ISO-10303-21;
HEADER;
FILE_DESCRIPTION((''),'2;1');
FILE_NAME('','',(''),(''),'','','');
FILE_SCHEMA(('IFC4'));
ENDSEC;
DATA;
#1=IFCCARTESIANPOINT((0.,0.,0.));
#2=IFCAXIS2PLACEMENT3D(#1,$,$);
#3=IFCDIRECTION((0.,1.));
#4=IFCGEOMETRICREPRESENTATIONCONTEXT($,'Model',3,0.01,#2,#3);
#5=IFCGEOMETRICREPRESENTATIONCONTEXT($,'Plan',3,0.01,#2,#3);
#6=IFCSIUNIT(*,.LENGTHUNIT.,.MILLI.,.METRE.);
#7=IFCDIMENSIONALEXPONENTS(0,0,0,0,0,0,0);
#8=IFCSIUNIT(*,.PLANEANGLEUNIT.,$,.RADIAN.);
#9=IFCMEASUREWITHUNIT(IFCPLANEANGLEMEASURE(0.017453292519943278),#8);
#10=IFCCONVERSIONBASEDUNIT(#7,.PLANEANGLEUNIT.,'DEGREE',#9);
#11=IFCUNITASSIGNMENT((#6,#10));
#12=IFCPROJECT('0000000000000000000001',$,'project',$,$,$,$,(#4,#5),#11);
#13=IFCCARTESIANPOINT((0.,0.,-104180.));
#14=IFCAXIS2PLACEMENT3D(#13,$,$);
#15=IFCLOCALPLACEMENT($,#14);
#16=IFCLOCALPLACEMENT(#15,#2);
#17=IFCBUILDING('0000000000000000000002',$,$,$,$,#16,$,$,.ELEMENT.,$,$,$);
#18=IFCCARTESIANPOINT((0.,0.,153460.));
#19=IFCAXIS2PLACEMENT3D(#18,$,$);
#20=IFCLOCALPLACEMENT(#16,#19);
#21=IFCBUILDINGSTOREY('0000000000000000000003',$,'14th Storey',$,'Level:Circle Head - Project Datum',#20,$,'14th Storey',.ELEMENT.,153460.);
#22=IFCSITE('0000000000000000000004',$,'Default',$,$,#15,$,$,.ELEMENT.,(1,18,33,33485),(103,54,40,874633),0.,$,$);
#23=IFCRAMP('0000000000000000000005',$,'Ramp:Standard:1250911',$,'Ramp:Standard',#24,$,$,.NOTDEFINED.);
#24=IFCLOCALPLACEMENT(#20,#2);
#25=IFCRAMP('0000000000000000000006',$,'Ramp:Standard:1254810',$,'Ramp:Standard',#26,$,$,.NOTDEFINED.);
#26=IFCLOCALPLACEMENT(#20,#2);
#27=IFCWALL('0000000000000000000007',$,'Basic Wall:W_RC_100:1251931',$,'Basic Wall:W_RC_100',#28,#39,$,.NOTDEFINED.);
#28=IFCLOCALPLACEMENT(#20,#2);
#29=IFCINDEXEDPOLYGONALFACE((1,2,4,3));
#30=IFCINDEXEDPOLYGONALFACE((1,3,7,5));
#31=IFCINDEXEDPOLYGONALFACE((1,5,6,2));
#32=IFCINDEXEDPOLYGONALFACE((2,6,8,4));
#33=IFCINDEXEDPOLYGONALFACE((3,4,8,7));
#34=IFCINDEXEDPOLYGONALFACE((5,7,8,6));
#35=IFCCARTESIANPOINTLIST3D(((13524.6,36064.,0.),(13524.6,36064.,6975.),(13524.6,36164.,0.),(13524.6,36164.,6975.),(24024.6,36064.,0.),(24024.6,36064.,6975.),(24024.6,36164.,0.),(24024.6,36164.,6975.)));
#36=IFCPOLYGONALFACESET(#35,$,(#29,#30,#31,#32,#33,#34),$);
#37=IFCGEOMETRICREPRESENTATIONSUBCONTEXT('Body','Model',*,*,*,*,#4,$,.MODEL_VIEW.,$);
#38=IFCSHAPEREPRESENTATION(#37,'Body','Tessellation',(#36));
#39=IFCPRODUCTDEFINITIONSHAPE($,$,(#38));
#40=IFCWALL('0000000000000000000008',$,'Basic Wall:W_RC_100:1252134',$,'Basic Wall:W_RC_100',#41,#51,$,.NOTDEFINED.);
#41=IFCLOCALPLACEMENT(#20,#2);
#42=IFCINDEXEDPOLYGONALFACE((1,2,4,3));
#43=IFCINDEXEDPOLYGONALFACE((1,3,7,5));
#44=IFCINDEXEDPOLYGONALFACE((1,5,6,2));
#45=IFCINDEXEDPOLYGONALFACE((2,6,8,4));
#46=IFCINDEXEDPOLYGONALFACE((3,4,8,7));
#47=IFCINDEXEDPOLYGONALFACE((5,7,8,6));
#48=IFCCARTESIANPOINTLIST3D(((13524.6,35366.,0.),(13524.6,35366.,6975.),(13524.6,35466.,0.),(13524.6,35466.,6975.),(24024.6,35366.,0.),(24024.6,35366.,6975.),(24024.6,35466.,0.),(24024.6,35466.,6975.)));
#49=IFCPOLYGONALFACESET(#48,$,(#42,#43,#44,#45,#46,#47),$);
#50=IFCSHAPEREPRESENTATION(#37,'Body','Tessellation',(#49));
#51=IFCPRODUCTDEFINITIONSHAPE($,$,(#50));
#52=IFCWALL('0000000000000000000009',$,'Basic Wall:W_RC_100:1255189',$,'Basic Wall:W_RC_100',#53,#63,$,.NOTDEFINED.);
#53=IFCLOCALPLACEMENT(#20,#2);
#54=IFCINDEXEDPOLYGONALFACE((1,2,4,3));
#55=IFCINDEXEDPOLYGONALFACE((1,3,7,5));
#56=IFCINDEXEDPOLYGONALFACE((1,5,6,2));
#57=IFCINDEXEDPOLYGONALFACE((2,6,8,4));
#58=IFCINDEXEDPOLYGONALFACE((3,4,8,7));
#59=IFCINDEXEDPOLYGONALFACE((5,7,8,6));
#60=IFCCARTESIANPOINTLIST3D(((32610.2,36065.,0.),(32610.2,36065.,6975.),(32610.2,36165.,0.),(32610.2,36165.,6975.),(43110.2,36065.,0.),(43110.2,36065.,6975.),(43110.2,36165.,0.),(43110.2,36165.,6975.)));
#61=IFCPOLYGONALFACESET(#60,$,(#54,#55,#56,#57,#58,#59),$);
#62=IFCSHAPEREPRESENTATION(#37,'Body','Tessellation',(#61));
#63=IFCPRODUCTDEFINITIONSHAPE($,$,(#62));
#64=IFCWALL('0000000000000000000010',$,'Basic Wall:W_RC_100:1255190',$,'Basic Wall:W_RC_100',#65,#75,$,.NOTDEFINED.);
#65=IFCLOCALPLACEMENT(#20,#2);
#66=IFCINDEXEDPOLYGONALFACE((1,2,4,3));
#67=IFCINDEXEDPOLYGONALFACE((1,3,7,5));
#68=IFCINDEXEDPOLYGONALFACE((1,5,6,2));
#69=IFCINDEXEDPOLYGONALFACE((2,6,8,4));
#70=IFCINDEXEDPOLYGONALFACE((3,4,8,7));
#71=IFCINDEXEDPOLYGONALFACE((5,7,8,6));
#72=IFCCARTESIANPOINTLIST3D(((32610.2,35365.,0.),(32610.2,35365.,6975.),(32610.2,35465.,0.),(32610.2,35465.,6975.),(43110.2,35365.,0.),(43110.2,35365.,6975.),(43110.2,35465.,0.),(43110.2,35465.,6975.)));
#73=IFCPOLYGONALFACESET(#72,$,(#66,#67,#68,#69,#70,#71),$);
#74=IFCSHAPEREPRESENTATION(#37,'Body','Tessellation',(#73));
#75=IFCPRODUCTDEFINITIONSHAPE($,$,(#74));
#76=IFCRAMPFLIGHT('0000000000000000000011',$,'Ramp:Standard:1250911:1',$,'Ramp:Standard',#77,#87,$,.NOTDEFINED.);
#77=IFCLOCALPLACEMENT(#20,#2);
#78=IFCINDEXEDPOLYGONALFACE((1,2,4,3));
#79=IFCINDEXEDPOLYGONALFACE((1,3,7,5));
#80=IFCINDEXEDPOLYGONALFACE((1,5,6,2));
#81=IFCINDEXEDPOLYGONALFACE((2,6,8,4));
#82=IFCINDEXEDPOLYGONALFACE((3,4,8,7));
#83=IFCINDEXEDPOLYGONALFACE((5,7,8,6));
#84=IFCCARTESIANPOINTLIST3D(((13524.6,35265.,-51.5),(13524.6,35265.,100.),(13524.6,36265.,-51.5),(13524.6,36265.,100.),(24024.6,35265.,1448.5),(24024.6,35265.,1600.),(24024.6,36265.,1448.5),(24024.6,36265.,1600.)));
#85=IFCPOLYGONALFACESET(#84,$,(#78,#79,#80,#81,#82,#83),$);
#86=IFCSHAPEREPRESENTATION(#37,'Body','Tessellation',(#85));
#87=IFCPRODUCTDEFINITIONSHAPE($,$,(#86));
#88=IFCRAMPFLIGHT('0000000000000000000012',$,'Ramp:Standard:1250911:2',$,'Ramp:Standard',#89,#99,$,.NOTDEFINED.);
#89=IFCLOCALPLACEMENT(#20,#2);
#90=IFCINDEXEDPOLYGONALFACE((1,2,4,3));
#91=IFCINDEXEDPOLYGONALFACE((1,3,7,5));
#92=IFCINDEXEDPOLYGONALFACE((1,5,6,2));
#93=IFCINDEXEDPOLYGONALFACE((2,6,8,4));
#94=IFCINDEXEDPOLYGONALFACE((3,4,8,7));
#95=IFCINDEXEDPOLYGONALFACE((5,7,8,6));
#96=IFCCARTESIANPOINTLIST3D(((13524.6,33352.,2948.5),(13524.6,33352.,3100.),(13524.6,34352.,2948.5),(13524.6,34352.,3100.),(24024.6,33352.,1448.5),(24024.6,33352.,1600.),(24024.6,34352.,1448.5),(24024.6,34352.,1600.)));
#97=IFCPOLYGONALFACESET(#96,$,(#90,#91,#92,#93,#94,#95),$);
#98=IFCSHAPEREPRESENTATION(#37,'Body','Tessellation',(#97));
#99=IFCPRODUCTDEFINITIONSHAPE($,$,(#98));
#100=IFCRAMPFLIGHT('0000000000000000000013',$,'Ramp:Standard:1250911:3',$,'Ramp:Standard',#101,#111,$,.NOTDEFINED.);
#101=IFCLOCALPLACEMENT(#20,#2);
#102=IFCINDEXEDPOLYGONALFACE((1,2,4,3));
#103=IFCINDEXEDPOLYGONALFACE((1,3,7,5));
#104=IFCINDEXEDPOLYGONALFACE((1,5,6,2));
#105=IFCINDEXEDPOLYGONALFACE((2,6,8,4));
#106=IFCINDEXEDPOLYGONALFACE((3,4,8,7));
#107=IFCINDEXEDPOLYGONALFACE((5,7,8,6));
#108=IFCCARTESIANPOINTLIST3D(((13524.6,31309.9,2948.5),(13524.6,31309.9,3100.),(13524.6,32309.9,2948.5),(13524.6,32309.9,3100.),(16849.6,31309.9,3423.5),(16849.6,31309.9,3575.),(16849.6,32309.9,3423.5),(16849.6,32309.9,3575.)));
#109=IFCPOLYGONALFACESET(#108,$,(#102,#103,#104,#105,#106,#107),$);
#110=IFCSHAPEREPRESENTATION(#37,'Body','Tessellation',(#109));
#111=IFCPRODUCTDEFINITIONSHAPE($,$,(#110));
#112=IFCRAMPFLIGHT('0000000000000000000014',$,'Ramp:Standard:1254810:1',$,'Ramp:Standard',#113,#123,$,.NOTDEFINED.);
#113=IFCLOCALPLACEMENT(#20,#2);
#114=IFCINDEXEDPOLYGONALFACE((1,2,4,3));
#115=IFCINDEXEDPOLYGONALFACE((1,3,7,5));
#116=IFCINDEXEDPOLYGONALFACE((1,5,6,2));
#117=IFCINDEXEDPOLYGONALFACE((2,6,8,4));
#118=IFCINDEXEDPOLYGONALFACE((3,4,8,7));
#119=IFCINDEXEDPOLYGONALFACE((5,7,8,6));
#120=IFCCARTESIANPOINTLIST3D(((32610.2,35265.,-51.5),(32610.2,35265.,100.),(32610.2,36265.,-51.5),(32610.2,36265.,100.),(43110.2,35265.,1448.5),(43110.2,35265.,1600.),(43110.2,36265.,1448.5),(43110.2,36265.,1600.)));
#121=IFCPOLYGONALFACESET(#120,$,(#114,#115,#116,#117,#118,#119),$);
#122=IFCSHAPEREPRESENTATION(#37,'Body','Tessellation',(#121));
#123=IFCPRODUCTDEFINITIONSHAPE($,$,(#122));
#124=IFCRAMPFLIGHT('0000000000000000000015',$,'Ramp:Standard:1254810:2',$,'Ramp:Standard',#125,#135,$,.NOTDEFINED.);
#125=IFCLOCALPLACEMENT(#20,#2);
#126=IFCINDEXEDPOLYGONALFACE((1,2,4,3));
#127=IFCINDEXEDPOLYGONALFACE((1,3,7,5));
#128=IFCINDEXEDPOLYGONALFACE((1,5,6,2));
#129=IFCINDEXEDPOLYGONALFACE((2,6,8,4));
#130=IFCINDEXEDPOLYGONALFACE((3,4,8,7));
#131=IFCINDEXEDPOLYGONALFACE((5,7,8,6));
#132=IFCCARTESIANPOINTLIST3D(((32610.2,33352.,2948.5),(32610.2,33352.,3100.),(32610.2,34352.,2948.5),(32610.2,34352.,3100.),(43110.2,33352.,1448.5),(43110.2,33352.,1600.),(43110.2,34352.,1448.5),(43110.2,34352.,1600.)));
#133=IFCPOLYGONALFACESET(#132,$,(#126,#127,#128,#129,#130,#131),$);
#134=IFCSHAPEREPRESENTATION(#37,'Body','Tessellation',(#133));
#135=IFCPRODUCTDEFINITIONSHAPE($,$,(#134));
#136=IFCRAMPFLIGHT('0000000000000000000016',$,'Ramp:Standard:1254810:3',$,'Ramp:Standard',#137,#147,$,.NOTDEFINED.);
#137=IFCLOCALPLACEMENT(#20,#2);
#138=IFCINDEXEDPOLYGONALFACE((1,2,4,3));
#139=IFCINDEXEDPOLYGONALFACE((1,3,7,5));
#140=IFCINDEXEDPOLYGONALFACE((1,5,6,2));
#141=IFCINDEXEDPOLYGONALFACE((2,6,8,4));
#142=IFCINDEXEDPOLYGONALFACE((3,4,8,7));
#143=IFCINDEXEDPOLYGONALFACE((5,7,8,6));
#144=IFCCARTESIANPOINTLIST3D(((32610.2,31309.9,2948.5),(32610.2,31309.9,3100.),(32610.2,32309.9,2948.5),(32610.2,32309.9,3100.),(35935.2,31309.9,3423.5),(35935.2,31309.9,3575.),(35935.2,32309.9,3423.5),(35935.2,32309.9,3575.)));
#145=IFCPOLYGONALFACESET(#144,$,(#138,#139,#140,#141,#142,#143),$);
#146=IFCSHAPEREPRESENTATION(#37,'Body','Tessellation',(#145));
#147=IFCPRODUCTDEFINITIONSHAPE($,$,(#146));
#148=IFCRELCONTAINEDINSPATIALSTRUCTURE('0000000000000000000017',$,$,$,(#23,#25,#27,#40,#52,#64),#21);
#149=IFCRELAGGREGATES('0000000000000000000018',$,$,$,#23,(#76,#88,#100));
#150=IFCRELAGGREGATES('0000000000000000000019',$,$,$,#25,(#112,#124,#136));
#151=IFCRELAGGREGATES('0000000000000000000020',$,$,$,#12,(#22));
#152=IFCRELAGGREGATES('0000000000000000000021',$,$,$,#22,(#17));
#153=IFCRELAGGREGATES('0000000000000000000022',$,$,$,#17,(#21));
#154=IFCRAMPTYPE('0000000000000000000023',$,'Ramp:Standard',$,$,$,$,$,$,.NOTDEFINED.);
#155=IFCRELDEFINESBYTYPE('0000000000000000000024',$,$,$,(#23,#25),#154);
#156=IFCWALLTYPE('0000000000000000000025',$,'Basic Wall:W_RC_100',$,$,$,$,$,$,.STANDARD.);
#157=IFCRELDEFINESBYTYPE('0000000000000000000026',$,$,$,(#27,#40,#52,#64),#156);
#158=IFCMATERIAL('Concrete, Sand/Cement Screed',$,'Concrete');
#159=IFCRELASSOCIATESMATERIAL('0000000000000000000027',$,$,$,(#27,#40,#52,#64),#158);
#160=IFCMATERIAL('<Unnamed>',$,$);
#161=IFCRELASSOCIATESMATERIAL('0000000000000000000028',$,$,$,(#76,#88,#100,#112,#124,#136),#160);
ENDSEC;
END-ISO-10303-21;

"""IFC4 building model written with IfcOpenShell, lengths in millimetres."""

from ifc_helpers import new_model, entity, si_unit, converted_unit, direction, frame, origin, place, context, subcontext, project, spatial, indexed_curve, outline, extrude, material, type_object, element, aggregate, save


model = new_model("IFC4")

# Units and contexts
model_context = context("Model", 3, precision=0.01, world=origin(), true_north=direction((0.0, 1.0)))
plan_context = context("Plan", 3, precision=0.01, world=origin(), true_north=direction((0.0, 1.0)))
body_context = subcontext(model_context, "Body", "Model", "MODEL_VIEW")
ifc_project = project(units=[si_unit("LENGTHUNIT", "METRE", prefix="MILLI"), converted_unit("PLANEANGLEUNIT", "DEGREE", entity("IfcPlaneAngleMeasure", 0.017453292519943278), si_unit("PLANEANGLEUNIT", "RADIAN"), dimensions=[0, 0, 0, 0, 0, 0, 0])], contexts=[model_context, plan_context])

# Site, building, storey
site_placement = place(None, frame((0.0, 0.0, -104180.0)))
site = spatial("IfcSite", under=ifc_project, at=site_placement, Name="Default", CompositionType="ELEMENT", RefLatitude=(1, 18, 33, 33485), RefLongitude=(103, 54, 40, 874633), RefElevation=0.0)
building_placement = place(site_placement, origin())
building = spatial("IfcBuilding", under=site, at=building_placement, CompositionType="ELEMENT")
storey_placement = place(building_placement, frame((0.0, 0.0, 153460.0)))
storey = spatial("IfcBuildingStorey", under=building, at=storey_placement, Name="14th Storey", ObjectType="Level:Circle Head - Project Datum", LongName="14th Storey", CompositionType="ELEMENT", Elevation=153460.0)

# Ramps
ramp_type = type_object("IfcRampType", Name="Ramp:Standard", PredefinedType="NOTDEFINED")
ramp_1_placement = place(storey_placement, origin())
ramp_1 = element("IfcRamp", 1, at=ramp_1_placement, inside=storey, type_object=ramp_type, Name="Ramp:Standard:1250911", ObjectType="Ramp:Standard", PredefinedType="NOTDEFINED")
ifc_material_1 = material(Name="<Unnamed>")
ramp_2_placement = place(storey_placement, origin())
ramp_2 = element("IfcRamp", 2, at=ramp_2_placement, inside=storey, type_object=ramp_type, Name="Ramp:Standard:1254810", ObjectType="Ramp:Standard", PredefinedType="NOTDEFINED")

# Walls
ifc_material_2 = material(Name="Concrete, Sand/Cement Screed", Category="Concrete")
wall_type = type_object("IfcWallType", Name="Basic Wall:W_RC_100", PredefinedType="STANDARD")
wall_1_placement = place(storey_placement, frame((13524.6, 36114.0, 0.0)))
element("IfcWall", 3, at=wall_1_placement, inside=storey, type_object=wall_type, material=ifc_material_2, Name="Basic Wall:W_RC_100:1251931", ObjectType="Basic Wall:W_RC_100", PredefinedType="NOTDEFINED", context=body_context, shape_type="SweptSolid", body=[
    extrude(outline(indexed_curve([(10500.0, 50.0), (0.0, 50.0), (0.0, -50.0), (10500.0, -50.0), (10500.0, 50.0)], self_intersect=False)), origin(), (0.0, 0.0, 1.0), 6975.0),
])
wall_2_placement = place(storey_placement, frame((13524.6, 35416.0, 0.0)))
element("IfcWall", 4, at=wall_2_placement, inside=storey, type_object=wall_type, material=ifc_material_2, Name="Basic Wall:W_RC_100:1252134", ObjectType="Basic Wall:W_RC_100", PredefinedType="NOTDEFINED", context=body_context, shape_type="SweptSolid", body=[
    extrude(outline(indexed_curve([(10500.0, 50.0), (0.0, 50.0), (0.0, -50.0), (10500.0, -50.0), (10500.0, 50.0)], self_intersect=False)), origin(), (0.0, 0.0, 1.0), 6975.0),
])
wall_3_placement = place(storey_placement, frame((32610.2, 36115.0, 0.0)))
element("IfcWall", 5, at=wall_3_placement, inside=storey, type_object=wall_type, material=ifc_material_2, Name="Basic Wall:W_RC_100:1255189", ObjectType="Basic Wall:W_RC_100", PredefinedType="NOTDEFINED", context=body_context, shape_type="SweptSolid", body=[
    extrude(outline(indexed_curve([(10500.0, 50.0), (0.0, 50.0), (0.0, -50.0), (10500.0, -50.0), (10500.0, 50.0)], self_intersect=False)), origin(), (0.0, 0.0, 1.0), 6975.0),
])
wall_4_placement = place(storey_placement, frame((32610.2, 35415.0, 0.0)))
element("IfcWall", 6, at=wall_4_placement, inside=storey, type_object=wall_type, material=ifc_material_2, Name="Basic Wall:W_RC_100:1255190", ObjectType="Basic Wall:W_RC_100", PredefinedType="NOTDEFINED", context=body_context, shape_type="SweptSolid", body=[
    extrude(outline(indexed_curve([(10500.0, 50.0), (0.0, 50.0), (0.0, -50.0), (10500.0, -50.0), (10500.0, 50.0)], self_intersect=False)), origin(), (0.0, 0.0, 1.0), 6975.0),
])

# Ramp flights
ramp_flight_1_placement = place(ramp_1_placement, origin())
ramp_flight_1 = element("IfcRampFlight", 7, at=ramp_flight_1_placement, material=ifc_material_1, Name="Ramp:Standard:1250911:1", ObjectType="Ramp:Standard", PredefinedType="NOTDEFINED", context=body_context, shape_type="SweptSolid", body=[
    extrude(outline(indexed_curve([(-825.8, -5250.0), (-674.2, -5250.0), (825.8, 5250.0), (674.2, 5250.0), (-825.8, -5250.0)], self_intersect=False)), frame((18774.6, 35265.0, 774.2), z_axis=(0.0, 1.0, 0.0), x_axis=(0.0, 0.0, -1.0)), (0.0, 0.0, 1.0), 1000.0),
])
ramp_flight_2_placement = place(ramp_1_placement, origin())
ramp_flight_2 = element("IfcRampFlight", 8, at=ramp_flight_2_placement, material=ifc_material_1, Name="Ramp:Standard:1250911:2", ObjectType="Ramp:Standard", PredefinedType="NOTDEFINED", context=body_context, shape_type="SweptSolid", body=[
    extrude(outline(indexed_curve([(674.2, -5250.0), (825.8, -5250.0), (-674.2, 5250.0), (-825.8, 5250.0), (674.2, -5250.0)], self_intersect=False)), frame((18774.6, 33352.0, 2274.2), z_axis=(0.0, 1.0, 0.0), x_axis=(0.0, 0.0, -1.0)), (0.0, 0.0, 1.0), 1000.0),
])
ramp_flight_3_placement = place(ramp_1_placement, origin())
ramp_flight_3 = element("IfcRampFlight", 9, at=ramp_flight_3_placement, material=ifc_material_1, Name="Ramp:Standard:1250911:3", ObjectType="Ramp:Standard", PredefinedType="NOTDEFINED", context=body_context, shape_type="SweptSolid", body=[
    extrude(outline(indexed_curve([(-313.3, -1662.5), (-161.7, -1662.5), (313.3, 1662.5), (161.7, 1662.5), (-313.3, -1662.5)], self_intersect=False)), frame((15187.1, 31309.9, 3261.7), z_axis=(0.0, 1.0, 0.0), x_axis=(0.0, 0.0, -1.0)), (0.0, 0.0, 1.0), 1000.0),
])
aggregate(ramp_1, [ramp_flight_1, ramp_flight_2, ramp_flight_3])
ramp_flight_4_placement = place(ramp_2_placement, origin())
ramp_flight_4 = element("IfcRampFlight", 10, at=ramp_flight_4_placement, material=ifc_material_1, Name="Ramp:Standard:1254810:1", ObjectType="Ramp:Standard", PredefinedType="NOTDEFINED", context=body_context, shape_type="SweptSolid", body=[
    extrude(outline(indexed_curve([(-825.8, -5250.0), (-674.2, -5250.0), (825.8, 5250.0), (674.2, 5250.0), (-825.8, -5250.0)], self_intersect=False)), frame((37860.2, 35265.0, 774.2), z_axis=(0.0, 1.0, 0.0), x_axis=(0.0, 0.0, -1.0)), (0.0, 0.0, 1.0), 1000.0),
])
ramp_flight_5_placement = place(ramp_2_placement, origin())
ramp_flight_5 = element("IfcRampFlight", 11, at=ramp_flight_5_placement, material=ifc_material_1, Name="Ramp:Standard:1254810:2", ObjectType="Ramp:Standard", PredefinedType="NOTDEFINED", context=body_context, shape_type="SweptSolid", body=[
    extrude(outline(indexed_curve([(674.2, -5250.0), (825.8, -5250.0), (-674.2, 5250.0), (-825.8, 5250.0), (674.2, -5250.0)], self_intersect=False)), frame((37860.2, 33352.0, 2274.2), z_axis=(0.0, 1.0, 0.0), x_axis=(0.0, 0.0, -1.0)), (0.0, 0.0, 1.0), 1000.0),
])
ramp_flight_6_placement = place(ramp_2_placement, origin())
ramp_flight_6 = element("IfcRampFlight", 12, at=ramp_flight_6_placement, material=ifc_material_1, Name="Ramp:Standard:1254810:3", ObjectType="Ramp:Standard", PredefinedType="NOTDEFINED", context=body_context, shape_type="SweptSolid", body=[
    extrude(outline(indexed_curve([(-313.3, -1662.5), (-161.7, -1662.5), (313.3, 1662.5), (161.7, 1662.5), (-313.3, -1662.5)], self_intersect=False)), frame((34272.7, 31309.9, 3261.7), z_axis=(0.0, 1.0, 0.0), x_axis=(0.0, 0.0, -1.0)), (0.0, 0.0, 1.0), 1000.0),
])
aggregate(ramp_2, [ramp_flight_4, ramp_flight_5, ramp_flight_6])

save(model, "model.ifc")
